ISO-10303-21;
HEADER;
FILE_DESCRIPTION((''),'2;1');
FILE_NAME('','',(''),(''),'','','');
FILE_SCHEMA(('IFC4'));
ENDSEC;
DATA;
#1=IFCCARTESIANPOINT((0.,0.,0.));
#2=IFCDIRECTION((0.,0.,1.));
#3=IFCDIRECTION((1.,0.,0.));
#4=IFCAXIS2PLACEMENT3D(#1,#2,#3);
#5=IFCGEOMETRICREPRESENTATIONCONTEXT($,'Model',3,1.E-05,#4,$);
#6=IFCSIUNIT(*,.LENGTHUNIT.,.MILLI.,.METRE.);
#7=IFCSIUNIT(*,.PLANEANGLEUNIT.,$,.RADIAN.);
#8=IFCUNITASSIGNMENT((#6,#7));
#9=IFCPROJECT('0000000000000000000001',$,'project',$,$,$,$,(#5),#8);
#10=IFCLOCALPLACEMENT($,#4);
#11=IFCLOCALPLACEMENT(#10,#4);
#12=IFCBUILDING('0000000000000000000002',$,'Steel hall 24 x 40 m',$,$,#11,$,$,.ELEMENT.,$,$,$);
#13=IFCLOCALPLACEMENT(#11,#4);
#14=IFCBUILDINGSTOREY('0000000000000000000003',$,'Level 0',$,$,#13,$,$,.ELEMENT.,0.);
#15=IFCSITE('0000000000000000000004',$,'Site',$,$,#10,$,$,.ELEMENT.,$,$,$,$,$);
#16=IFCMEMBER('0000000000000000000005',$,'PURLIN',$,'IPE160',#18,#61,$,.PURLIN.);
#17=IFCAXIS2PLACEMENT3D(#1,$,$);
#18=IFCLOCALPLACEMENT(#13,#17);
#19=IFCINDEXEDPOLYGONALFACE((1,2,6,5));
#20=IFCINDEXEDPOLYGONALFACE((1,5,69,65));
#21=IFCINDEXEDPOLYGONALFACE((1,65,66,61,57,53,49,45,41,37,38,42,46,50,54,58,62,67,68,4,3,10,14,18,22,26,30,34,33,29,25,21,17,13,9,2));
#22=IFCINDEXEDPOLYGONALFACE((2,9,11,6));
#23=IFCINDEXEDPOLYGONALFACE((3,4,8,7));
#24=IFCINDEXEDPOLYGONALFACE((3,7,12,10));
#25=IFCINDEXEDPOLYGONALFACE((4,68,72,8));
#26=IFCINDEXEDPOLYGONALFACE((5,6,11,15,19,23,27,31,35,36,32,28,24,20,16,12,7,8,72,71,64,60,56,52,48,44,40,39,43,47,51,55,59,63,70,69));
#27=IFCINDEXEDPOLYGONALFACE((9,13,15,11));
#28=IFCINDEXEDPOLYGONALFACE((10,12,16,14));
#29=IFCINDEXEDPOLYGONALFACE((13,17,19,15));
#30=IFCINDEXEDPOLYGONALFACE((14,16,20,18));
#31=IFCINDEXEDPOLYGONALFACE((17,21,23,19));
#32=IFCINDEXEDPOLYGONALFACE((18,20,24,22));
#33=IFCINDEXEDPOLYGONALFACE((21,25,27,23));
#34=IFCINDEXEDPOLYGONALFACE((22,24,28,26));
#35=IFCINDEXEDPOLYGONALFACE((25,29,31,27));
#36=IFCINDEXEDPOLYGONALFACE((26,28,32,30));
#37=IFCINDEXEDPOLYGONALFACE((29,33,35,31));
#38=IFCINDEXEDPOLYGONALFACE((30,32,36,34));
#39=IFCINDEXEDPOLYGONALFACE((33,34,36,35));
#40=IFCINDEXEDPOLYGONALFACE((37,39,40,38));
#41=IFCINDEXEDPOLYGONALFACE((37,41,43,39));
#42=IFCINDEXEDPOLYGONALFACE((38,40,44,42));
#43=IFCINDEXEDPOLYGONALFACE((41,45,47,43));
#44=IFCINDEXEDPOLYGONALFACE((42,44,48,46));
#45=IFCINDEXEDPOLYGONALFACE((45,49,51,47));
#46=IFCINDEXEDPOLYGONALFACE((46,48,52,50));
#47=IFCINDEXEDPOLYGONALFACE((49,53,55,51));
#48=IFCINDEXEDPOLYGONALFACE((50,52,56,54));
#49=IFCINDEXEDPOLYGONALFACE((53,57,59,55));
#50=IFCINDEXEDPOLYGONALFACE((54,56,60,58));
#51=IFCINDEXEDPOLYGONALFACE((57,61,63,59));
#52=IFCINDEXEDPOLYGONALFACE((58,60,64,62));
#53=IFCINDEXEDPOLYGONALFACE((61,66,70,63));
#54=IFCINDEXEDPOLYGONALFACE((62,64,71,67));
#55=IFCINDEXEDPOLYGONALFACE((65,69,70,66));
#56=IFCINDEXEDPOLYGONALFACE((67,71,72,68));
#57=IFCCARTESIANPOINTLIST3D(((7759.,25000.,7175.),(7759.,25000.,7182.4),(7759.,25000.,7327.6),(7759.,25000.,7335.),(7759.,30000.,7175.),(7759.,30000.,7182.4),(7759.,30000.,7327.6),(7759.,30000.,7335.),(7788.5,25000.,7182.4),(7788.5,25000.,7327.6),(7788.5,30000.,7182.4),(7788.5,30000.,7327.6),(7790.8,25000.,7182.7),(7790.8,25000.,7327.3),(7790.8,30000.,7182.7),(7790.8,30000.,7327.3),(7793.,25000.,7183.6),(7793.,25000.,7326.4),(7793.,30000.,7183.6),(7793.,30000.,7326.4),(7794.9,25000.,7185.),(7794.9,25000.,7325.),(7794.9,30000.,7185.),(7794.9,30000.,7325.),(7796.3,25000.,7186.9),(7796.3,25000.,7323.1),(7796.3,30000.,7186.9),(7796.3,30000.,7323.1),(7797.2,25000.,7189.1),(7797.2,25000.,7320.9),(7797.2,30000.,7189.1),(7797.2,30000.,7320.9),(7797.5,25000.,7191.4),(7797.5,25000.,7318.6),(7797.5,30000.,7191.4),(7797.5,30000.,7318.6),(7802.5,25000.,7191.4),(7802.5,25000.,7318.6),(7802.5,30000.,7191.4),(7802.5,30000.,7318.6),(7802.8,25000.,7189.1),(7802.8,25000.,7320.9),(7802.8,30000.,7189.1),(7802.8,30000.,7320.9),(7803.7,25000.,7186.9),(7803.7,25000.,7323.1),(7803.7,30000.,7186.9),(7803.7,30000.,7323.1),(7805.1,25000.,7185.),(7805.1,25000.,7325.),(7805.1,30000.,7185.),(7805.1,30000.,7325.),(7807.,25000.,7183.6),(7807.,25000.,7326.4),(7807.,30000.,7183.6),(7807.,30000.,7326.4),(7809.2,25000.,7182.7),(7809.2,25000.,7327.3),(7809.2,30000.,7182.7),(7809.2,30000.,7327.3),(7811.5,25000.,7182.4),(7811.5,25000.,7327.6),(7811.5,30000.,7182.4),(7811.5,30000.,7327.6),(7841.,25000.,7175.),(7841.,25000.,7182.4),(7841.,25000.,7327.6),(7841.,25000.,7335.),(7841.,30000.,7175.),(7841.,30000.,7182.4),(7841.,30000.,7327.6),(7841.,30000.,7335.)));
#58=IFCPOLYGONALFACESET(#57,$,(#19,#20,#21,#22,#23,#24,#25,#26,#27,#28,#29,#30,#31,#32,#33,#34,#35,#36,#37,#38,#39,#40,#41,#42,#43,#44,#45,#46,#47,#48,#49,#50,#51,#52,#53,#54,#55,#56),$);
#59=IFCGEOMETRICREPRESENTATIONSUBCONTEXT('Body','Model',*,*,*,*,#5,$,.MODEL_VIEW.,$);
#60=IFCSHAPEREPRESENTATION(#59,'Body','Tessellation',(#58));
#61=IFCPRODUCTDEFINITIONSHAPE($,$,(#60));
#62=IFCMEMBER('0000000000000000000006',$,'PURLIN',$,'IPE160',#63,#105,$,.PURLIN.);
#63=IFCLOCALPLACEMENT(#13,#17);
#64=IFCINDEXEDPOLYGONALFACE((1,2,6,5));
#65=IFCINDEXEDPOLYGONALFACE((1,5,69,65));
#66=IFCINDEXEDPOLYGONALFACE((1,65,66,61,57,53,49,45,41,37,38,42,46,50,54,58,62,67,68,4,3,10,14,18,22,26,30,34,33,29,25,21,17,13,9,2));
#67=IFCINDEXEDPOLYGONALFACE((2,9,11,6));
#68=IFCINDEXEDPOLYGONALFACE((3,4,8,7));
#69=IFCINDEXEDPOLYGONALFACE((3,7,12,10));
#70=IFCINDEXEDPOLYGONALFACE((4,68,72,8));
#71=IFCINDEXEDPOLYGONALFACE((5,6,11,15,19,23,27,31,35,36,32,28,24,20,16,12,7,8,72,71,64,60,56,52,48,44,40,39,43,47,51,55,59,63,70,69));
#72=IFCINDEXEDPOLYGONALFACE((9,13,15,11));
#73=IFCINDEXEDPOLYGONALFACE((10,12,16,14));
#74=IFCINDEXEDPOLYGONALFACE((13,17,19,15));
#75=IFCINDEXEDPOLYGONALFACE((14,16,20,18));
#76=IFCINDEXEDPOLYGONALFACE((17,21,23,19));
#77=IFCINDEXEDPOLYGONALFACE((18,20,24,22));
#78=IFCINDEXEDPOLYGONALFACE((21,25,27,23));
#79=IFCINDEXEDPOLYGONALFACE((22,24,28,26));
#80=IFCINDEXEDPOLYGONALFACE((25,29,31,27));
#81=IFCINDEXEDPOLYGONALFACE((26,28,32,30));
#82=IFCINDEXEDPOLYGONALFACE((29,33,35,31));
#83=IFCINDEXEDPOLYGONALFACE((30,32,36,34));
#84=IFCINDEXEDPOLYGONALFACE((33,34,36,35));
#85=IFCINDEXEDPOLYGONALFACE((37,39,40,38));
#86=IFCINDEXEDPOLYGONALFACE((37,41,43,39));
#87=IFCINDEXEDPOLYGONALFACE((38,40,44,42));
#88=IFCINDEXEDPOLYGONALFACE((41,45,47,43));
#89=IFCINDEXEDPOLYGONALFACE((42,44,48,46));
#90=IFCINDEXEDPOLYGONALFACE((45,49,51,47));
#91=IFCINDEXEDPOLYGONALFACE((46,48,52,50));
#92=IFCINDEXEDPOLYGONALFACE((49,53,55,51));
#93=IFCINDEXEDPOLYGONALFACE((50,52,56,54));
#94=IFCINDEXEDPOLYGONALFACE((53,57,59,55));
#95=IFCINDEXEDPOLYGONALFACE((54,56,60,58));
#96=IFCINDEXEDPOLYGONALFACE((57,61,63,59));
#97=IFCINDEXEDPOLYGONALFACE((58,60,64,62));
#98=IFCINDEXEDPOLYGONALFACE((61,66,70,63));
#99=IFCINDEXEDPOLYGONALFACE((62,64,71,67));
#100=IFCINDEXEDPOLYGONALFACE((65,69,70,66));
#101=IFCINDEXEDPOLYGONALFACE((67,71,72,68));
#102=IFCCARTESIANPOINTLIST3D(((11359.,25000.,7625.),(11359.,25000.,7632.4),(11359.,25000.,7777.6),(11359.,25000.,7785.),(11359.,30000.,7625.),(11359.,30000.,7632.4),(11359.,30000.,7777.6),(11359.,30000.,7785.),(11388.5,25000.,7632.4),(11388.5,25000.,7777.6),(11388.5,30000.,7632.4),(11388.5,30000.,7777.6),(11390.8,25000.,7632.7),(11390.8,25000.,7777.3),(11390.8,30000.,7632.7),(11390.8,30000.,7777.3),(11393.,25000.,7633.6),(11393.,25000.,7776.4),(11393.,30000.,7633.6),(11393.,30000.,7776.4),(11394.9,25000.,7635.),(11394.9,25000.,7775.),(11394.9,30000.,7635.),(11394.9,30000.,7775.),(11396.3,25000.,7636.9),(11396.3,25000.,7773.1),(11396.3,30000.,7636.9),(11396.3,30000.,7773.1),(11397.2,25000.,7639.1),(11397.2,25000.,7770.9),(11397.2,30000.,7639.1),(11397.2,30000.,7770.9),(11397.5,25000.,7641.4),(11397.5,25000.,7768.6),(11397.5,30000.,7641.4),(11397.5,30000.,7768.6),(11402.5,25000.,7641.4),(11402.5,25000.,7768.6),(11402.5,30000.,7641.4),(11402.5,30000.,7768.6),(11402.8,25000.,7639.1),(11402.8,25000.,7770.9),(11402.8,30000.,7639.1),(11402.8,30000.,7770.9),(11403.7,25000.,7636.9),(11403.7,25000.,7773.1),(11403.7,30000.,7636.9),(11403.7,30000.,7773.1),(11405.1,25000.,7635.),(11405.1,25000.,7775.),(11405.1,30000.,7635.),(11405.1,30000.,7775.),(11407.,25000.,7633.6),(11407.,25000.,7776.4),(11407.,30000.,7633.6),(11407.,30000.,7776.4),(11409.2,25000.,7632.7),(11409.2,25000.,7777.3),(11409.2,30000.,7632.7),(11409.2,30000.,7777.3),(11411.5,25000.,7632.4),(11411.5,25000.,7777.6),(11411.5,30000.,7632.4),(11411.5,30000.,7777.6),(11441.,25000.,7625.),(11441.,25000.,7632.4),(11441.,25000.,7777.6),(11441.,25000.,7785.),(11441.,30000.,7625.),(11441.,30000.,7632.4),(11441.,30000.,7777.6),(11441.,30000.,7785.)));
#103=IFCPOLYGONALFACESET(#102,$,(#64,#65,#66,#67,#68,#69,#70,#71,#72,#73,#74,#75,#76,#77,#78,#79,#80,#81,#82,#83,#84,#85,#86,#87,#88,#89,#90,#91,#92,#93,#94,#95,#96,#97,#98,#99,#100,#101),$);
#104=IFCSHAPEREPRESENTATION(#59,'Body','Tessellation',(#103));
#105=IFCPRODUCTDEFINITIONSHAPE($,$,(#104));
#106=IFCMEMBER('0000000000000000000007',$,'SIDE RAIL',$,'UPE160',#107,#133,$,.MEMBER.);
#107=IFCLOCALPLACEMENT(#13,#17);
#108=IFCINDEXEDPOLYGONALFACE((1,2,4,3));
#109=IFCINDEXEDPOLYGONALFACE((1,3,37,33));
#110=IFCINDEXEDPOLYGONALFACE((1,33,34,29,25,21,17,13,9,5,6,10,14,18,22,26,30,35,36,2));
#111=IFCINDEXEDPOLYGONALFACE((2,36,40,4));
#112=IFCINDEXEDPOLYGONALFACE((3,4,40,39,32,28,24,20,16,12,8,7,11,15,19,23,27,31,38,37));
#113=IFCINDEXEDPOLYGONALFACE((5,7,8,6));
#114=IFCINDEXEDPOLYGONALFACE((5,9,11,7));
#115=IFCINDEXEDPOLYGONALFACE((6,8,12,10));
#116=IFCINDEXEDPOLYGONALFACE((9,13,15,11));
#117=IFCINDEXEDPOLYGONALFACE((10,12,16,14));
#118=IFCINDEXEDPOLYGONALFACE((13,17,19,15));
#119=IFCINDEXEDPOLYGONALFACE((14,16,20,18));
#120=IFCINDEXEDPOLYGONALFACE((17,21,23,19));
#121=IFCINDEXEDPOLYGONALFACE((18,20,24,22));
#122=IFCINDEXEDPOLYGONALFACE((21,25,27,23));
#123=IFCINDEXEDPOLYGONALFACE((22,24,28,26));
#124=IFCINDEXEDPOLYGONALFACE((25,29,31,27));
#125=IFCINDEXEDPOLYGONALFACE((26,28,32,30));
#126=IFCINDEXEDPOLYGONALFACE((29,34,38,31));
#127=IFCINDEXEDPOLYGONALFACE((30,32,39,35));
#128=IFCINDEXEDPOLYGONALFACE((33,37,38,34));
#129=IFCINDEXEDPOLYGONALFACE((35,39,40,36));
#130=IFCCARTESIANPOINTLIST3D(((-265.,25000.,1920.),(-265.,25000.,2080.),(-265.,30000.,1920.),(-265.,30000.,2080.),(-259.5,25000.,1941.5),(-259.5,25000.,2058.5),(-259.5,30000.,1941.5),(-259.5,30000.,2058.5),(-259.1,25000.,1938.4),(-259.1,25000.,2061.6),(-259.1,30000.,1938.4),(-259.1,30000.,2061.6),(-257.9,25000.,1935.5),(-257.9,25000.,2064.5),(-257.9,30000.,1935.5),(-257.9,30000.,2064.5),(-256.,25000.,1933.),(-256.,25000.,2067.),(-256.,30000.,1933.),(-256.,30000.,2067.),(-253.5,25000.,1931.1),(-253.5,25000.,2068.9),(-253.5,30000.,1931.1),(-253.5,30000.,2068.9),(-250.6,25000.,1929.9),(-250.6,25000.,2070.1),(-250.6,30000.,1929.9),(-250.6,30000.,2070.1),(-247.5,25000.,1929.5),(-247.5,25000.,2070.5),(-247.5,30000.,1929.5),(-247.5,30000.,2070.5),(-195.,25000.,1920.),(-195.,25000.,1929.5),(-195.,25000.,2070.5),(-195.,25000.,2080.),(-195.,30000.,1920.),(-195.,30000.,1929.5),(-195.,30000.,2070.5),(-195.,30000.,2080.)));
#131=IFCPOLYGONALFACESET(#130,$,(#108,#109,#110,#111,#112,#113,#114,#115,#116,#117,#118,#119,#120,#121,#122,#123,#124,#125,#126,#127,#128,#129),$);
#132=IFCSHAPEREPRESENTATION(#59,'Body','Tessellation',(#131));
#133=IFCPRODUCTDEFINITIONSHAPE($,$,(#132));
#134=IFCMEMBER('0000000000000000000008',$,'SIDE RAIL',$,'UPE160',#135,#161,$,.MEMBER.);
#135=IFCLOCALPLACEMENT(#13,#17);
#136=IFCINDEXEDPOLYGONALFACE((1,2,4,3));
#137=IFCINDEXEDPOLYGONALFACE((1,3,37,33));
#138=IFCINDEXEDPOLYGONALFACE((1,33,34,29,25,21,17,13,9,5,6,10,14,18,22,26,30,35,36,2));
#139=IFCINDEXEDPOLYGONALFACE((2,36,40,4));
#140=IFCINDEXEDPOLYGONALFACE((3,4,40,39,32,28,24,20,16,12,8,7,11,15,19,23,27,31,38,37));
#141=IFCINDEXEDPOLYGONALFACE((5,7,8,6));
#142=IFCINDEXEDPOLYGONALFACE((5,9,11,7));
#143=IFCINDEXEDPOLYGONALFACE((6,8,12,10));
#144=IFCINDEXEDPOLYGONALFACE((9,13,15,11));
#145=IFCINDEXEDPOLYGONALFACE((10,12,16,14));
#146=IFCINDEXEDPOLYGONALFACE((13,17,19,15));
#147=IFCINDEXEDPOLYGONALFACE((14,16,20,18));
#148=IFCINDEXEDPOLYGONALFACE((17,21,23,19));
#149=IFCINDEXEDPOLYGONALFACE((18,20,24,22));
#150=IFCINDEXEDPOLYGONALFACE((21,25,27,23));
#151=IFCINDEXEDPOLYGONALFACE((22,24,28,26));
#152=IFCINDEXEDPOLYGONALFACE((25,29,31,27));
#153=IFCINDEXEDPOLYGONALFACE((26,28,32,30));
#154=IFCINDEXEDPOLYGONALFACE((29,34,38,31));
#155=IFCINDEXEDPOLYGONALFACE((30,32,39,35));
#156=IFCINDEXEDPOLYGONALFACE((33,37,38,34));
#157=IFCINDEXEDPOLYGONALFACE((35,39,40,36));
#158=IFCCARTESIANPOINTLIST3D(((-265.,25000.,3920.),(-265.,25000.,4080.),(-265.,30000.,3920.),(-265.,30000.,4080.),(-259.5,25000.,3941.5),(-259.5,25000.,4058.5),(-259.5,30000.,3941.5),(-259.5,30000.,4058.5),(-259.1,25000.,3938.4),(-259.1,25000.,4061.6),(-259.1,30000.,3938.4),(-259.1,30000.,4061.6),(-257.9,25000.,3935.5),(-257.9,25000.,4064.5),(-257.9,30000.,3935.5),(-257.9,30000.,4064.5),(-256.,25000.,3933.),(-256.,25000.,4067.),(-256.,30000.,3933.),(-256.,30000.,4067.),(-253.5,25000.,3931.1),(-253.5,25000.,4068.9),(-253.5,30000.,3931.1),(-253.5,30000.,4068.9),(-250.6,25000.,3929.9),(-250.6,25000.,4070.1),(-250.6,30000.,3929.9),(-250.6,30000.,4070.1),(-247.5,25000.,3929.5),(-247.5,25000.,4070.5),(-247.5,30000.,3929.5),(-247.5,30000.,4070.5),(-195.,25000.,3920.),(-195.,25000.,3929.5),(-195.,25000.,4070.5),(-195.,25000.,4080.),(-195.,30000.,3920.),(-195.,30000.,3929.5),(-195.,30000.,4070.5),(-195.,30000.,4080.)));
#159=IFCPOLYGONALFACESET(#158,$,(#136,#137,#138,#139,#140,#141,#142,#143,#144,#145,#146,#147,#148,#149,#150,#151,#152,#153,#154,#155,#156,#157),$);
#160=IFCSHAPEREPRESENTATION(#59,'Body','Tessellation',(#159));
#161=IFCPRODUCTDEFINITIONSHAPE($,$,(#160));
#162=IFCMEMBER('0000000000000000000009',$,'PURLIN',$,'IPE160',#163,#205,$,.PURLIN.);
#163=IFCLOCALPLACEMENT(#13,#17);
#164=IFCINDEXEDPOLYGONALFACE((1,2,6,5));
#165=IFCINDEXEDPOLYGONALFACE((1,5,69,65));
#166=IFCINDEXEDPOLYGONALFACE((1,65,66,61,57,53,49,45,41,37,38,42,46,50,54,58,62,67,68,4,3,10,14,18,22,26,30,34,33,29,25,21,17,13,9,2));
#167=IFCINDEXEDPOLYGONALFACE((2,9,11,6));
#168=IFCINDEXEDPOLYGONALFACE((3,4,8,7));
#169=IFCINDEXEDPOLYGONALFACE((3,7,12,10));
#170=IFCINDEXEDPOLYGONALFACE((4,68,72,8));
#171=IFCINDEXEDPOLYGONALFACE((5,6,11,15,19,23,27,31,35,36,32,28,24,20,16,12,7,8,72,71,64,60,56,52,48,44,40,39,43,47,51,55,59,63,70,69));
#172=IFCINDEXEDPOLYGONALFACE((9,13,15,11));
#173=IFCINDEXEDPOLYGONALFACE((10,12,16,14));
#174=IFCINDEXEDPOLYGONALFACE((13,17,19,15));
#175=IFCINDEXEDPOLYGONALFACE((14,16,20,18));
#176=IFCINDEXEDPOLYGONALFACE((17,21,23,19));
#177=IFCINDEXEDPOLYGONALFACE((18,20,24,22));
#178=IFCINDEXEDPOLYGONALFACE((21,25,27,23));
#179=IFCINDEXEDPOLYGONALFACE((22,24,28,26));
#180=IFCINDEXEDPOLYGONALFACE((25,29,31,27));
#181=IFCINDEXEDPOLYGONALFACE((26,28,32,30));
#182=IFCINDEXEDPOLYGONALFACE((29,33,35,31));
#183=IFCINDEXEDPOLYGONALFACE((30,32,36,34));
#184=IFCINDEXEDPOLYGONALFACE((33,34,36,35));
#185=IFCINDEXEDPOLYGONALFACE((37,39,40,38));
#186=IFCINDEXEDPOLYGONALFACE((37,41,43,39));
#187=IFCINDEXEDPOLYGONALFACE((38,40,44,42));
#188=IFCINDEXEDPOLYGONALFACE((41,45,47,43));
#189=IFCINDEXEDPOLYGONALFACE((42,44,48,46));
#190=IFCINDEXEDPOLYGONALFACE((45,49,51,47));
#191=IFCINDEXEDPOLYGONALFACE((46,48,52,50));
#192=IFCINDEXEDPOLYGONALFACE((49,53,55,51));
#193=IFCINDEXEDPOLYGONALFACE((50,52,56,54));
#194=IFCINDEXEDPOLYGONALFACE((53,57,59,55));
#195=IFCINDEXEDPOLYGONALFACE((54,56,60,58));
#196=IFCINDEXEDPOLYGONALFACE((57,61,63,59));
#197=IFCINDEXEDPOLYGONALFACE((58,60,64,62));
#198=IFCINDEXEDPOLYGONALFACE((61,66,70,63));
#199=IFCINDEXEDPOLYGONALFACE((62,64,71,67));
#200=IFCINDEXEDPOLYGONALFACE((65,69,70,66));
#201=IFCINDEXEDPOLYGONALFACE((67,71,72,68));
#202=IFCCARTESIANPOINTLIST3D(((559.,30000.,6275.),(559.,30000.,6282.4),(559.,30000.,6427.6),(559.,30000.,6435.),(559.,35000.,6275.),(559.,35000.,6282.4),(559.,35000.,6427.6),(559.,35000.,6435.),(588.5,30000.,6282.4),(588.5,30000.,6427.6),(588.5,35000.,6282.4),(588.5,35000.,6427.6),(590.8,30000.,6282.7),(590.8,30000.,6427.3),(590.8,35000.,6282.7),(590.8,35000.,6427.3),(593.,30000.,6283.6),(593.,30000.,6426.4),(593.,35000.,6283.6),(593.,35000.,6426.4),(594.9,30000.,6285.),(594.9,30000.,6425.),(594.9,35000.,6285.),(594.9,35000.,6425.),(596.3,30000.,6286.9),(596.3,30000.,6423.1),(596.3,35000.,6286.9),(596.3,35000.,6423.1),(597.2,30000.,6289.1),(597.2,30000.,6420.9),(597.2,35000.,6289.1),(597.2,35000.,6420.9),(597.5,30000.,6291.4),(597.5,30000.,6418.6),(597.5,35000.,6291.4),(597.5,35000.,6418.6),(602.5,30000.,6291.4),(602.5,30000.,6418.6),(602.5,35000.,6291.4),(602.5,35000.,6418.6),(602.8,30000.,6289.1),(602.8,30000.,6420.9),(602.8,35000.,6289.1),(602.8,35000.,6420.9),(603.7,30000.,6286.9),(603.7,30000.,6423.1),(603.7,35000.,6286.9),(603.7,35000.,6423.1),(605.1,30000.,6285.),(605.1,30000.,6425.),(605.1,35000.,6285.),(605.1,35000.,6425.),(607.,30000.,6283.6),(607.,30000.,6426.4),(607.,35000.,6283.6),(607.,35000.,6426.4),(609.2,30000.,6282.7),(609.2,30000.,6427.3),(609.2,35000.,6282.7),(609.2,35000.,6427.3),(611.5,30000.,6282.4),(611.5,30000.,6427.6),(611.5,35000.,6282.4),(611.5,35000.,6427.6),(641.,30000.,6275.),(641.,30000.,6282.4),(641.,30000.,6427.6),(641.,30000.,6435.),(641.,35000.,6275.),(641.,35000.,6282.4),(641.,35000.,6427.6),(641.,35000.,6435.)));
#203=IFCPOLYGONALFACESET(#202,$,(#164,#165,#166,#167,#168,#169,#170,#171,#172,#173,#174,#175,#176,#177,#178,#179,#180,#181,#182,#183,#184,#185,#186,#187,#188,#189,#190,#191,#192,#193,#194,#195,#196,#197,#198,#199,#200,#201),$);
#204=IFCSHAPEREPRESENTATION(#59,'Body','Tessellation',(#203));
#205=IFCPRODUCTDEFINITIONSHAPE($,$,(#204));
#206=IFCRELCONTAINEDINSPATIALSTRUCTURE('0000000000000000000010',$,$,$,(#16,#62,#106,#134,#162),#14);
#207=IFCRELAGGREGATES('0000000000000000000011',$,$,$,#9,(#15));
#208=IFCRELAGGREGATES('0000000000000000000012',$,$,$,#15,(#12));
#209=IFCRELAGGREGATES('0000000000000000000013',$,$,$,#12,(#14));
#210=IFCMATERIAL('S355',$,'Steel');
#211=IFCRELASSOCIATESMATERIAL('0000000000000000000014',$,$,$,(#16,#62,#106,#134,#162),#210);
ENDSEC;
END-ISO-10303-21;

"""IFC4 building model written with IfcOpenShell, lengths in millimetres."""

from ifc_helpers import new_model, si_unit, frame, origin_with_axes, place, context, subcontext, project, spatial, i_section, u_section, extrude, material, element, save


model = new_model("IFC4")

# Units and contexts
model_context = context("Model", 3, precision=1e-05, world=origin_with_axes())
body_context = subcontext(model_context, "Body", "Model", "MODEL_VIEW")
ifc_project = project(units=[si_unit("LENGTHUNIT", "METRE", prefix="MILLI"), si_unit("PLANEANGLEUNIT", "RADIAN")], contexts=[model_context])

# Site, building, storey
site_placement = place(None, origin_with_axes())
site = spatial("IfcSite", under=ifc_project, at=site_placement, Name="Site", CompositionType="ELEMENT")
building_placement = place(site_placement, origin_with_axes())
building = spatial("IfcBuilding", under=site, at=building_placement, Name="Steel hall 24 x 40 m", CompositionType="ELEMENT")
storey_placement = place(building_placement, origin_with_axes())
storey = spatial("IfcBuildingStorey", under=building, at=storey_placement, Name="Level 0", CompositionType="ELEMENT", Elevation=0.0)

# Shared definitions
ifc_material = material(Name="S355", Category="Steel")

# Members
for number, where, z_axis, x_axis, name in (
    (1, (7800.0, 25000.0, 7255.0), (0.0, 1.0, 0.0), (1.0, 0.0, 0.0), "PURLIN"),
    (2, (11400.0, 25000.0, 7705.0), (0.0, 1.0, 0.0), (1.0, 0.0, 0.0), "PURLIN"),
):
    element("IfcMember", number, at=place(storey_placement, frame(where, z_axis=z_axis, x_axis=x_axis)), inside=storey, material=ifc_material, Name=name, ObjectType="IPE160", PredefinedType="PURLIN", context=body_context, shape_type="SweptSolid", body=[
        extrude(i_section(OverallWidth=82.0, OverallDepth=160.0, WebThickness=5.0, FlangeThickness=7.4, FilletRadius=9.0), origin_with_axes(), (0.0, 0.0, 1.0), 5000.0),
    ])
for number, where, z_axis, x_axis, name in (
    (3, (-230.0, 25000.0, 2000.0), (0.0, 1.0, 0.0), (1.0, 0.0, 0.0), "SIDE RAIL"),
    (4, (-230.0, 25000.0, 4000.0), (0.0, 1.0, 0.0), (1.0, 0.0, 0.0), "SIDE RAIL"),
):
    element("IfcMember", number, at=place(storey_placement, frame(where, z_axis=z_axis, x_axis=x_axis)), inside=storey, material=ifc_material, Name=name, ObjectType="UPE160", PredefinedType="MEMBER", context=body_context, shape_type="SweptSolid", body=[
        extrude(u_section(Depth=160.0, FlangeWidth=70.0, WebThickness=5.5, FlangeThickness=9.5, FilletRadius=12.0), origin_with_axes(), (0.0, 0.0, 1.0), 5000.0),
    ])
for number, where, z_axis, x_axis, name in (
    (5, (600.0, 30000.0, 6355.0), (0.0, 1.0, 0.0), (1.0, 0.0, 0.0), "PURLIN"),
):
    element("IfcMember", number, at=place(storey_placement, frame(where, z_axis=z_axis, x_axis=x_axis)), inside=storey, material=ifc_material, Name=name, ObjectType="IPE160", PredefinedType="PURLIN", context=body_context, shape_type="SweptSolid", body=[
        extrude(i_section(OverallWidth=82.0, OverallDepth=160.0, WebThickness=5.0, FlangeThickness=7.4, FilletRadius=9.0), origin_with_axes(), (0.0, 0.0, 1.0), 5000.0),
    ])

save(model, "model.ifc")
